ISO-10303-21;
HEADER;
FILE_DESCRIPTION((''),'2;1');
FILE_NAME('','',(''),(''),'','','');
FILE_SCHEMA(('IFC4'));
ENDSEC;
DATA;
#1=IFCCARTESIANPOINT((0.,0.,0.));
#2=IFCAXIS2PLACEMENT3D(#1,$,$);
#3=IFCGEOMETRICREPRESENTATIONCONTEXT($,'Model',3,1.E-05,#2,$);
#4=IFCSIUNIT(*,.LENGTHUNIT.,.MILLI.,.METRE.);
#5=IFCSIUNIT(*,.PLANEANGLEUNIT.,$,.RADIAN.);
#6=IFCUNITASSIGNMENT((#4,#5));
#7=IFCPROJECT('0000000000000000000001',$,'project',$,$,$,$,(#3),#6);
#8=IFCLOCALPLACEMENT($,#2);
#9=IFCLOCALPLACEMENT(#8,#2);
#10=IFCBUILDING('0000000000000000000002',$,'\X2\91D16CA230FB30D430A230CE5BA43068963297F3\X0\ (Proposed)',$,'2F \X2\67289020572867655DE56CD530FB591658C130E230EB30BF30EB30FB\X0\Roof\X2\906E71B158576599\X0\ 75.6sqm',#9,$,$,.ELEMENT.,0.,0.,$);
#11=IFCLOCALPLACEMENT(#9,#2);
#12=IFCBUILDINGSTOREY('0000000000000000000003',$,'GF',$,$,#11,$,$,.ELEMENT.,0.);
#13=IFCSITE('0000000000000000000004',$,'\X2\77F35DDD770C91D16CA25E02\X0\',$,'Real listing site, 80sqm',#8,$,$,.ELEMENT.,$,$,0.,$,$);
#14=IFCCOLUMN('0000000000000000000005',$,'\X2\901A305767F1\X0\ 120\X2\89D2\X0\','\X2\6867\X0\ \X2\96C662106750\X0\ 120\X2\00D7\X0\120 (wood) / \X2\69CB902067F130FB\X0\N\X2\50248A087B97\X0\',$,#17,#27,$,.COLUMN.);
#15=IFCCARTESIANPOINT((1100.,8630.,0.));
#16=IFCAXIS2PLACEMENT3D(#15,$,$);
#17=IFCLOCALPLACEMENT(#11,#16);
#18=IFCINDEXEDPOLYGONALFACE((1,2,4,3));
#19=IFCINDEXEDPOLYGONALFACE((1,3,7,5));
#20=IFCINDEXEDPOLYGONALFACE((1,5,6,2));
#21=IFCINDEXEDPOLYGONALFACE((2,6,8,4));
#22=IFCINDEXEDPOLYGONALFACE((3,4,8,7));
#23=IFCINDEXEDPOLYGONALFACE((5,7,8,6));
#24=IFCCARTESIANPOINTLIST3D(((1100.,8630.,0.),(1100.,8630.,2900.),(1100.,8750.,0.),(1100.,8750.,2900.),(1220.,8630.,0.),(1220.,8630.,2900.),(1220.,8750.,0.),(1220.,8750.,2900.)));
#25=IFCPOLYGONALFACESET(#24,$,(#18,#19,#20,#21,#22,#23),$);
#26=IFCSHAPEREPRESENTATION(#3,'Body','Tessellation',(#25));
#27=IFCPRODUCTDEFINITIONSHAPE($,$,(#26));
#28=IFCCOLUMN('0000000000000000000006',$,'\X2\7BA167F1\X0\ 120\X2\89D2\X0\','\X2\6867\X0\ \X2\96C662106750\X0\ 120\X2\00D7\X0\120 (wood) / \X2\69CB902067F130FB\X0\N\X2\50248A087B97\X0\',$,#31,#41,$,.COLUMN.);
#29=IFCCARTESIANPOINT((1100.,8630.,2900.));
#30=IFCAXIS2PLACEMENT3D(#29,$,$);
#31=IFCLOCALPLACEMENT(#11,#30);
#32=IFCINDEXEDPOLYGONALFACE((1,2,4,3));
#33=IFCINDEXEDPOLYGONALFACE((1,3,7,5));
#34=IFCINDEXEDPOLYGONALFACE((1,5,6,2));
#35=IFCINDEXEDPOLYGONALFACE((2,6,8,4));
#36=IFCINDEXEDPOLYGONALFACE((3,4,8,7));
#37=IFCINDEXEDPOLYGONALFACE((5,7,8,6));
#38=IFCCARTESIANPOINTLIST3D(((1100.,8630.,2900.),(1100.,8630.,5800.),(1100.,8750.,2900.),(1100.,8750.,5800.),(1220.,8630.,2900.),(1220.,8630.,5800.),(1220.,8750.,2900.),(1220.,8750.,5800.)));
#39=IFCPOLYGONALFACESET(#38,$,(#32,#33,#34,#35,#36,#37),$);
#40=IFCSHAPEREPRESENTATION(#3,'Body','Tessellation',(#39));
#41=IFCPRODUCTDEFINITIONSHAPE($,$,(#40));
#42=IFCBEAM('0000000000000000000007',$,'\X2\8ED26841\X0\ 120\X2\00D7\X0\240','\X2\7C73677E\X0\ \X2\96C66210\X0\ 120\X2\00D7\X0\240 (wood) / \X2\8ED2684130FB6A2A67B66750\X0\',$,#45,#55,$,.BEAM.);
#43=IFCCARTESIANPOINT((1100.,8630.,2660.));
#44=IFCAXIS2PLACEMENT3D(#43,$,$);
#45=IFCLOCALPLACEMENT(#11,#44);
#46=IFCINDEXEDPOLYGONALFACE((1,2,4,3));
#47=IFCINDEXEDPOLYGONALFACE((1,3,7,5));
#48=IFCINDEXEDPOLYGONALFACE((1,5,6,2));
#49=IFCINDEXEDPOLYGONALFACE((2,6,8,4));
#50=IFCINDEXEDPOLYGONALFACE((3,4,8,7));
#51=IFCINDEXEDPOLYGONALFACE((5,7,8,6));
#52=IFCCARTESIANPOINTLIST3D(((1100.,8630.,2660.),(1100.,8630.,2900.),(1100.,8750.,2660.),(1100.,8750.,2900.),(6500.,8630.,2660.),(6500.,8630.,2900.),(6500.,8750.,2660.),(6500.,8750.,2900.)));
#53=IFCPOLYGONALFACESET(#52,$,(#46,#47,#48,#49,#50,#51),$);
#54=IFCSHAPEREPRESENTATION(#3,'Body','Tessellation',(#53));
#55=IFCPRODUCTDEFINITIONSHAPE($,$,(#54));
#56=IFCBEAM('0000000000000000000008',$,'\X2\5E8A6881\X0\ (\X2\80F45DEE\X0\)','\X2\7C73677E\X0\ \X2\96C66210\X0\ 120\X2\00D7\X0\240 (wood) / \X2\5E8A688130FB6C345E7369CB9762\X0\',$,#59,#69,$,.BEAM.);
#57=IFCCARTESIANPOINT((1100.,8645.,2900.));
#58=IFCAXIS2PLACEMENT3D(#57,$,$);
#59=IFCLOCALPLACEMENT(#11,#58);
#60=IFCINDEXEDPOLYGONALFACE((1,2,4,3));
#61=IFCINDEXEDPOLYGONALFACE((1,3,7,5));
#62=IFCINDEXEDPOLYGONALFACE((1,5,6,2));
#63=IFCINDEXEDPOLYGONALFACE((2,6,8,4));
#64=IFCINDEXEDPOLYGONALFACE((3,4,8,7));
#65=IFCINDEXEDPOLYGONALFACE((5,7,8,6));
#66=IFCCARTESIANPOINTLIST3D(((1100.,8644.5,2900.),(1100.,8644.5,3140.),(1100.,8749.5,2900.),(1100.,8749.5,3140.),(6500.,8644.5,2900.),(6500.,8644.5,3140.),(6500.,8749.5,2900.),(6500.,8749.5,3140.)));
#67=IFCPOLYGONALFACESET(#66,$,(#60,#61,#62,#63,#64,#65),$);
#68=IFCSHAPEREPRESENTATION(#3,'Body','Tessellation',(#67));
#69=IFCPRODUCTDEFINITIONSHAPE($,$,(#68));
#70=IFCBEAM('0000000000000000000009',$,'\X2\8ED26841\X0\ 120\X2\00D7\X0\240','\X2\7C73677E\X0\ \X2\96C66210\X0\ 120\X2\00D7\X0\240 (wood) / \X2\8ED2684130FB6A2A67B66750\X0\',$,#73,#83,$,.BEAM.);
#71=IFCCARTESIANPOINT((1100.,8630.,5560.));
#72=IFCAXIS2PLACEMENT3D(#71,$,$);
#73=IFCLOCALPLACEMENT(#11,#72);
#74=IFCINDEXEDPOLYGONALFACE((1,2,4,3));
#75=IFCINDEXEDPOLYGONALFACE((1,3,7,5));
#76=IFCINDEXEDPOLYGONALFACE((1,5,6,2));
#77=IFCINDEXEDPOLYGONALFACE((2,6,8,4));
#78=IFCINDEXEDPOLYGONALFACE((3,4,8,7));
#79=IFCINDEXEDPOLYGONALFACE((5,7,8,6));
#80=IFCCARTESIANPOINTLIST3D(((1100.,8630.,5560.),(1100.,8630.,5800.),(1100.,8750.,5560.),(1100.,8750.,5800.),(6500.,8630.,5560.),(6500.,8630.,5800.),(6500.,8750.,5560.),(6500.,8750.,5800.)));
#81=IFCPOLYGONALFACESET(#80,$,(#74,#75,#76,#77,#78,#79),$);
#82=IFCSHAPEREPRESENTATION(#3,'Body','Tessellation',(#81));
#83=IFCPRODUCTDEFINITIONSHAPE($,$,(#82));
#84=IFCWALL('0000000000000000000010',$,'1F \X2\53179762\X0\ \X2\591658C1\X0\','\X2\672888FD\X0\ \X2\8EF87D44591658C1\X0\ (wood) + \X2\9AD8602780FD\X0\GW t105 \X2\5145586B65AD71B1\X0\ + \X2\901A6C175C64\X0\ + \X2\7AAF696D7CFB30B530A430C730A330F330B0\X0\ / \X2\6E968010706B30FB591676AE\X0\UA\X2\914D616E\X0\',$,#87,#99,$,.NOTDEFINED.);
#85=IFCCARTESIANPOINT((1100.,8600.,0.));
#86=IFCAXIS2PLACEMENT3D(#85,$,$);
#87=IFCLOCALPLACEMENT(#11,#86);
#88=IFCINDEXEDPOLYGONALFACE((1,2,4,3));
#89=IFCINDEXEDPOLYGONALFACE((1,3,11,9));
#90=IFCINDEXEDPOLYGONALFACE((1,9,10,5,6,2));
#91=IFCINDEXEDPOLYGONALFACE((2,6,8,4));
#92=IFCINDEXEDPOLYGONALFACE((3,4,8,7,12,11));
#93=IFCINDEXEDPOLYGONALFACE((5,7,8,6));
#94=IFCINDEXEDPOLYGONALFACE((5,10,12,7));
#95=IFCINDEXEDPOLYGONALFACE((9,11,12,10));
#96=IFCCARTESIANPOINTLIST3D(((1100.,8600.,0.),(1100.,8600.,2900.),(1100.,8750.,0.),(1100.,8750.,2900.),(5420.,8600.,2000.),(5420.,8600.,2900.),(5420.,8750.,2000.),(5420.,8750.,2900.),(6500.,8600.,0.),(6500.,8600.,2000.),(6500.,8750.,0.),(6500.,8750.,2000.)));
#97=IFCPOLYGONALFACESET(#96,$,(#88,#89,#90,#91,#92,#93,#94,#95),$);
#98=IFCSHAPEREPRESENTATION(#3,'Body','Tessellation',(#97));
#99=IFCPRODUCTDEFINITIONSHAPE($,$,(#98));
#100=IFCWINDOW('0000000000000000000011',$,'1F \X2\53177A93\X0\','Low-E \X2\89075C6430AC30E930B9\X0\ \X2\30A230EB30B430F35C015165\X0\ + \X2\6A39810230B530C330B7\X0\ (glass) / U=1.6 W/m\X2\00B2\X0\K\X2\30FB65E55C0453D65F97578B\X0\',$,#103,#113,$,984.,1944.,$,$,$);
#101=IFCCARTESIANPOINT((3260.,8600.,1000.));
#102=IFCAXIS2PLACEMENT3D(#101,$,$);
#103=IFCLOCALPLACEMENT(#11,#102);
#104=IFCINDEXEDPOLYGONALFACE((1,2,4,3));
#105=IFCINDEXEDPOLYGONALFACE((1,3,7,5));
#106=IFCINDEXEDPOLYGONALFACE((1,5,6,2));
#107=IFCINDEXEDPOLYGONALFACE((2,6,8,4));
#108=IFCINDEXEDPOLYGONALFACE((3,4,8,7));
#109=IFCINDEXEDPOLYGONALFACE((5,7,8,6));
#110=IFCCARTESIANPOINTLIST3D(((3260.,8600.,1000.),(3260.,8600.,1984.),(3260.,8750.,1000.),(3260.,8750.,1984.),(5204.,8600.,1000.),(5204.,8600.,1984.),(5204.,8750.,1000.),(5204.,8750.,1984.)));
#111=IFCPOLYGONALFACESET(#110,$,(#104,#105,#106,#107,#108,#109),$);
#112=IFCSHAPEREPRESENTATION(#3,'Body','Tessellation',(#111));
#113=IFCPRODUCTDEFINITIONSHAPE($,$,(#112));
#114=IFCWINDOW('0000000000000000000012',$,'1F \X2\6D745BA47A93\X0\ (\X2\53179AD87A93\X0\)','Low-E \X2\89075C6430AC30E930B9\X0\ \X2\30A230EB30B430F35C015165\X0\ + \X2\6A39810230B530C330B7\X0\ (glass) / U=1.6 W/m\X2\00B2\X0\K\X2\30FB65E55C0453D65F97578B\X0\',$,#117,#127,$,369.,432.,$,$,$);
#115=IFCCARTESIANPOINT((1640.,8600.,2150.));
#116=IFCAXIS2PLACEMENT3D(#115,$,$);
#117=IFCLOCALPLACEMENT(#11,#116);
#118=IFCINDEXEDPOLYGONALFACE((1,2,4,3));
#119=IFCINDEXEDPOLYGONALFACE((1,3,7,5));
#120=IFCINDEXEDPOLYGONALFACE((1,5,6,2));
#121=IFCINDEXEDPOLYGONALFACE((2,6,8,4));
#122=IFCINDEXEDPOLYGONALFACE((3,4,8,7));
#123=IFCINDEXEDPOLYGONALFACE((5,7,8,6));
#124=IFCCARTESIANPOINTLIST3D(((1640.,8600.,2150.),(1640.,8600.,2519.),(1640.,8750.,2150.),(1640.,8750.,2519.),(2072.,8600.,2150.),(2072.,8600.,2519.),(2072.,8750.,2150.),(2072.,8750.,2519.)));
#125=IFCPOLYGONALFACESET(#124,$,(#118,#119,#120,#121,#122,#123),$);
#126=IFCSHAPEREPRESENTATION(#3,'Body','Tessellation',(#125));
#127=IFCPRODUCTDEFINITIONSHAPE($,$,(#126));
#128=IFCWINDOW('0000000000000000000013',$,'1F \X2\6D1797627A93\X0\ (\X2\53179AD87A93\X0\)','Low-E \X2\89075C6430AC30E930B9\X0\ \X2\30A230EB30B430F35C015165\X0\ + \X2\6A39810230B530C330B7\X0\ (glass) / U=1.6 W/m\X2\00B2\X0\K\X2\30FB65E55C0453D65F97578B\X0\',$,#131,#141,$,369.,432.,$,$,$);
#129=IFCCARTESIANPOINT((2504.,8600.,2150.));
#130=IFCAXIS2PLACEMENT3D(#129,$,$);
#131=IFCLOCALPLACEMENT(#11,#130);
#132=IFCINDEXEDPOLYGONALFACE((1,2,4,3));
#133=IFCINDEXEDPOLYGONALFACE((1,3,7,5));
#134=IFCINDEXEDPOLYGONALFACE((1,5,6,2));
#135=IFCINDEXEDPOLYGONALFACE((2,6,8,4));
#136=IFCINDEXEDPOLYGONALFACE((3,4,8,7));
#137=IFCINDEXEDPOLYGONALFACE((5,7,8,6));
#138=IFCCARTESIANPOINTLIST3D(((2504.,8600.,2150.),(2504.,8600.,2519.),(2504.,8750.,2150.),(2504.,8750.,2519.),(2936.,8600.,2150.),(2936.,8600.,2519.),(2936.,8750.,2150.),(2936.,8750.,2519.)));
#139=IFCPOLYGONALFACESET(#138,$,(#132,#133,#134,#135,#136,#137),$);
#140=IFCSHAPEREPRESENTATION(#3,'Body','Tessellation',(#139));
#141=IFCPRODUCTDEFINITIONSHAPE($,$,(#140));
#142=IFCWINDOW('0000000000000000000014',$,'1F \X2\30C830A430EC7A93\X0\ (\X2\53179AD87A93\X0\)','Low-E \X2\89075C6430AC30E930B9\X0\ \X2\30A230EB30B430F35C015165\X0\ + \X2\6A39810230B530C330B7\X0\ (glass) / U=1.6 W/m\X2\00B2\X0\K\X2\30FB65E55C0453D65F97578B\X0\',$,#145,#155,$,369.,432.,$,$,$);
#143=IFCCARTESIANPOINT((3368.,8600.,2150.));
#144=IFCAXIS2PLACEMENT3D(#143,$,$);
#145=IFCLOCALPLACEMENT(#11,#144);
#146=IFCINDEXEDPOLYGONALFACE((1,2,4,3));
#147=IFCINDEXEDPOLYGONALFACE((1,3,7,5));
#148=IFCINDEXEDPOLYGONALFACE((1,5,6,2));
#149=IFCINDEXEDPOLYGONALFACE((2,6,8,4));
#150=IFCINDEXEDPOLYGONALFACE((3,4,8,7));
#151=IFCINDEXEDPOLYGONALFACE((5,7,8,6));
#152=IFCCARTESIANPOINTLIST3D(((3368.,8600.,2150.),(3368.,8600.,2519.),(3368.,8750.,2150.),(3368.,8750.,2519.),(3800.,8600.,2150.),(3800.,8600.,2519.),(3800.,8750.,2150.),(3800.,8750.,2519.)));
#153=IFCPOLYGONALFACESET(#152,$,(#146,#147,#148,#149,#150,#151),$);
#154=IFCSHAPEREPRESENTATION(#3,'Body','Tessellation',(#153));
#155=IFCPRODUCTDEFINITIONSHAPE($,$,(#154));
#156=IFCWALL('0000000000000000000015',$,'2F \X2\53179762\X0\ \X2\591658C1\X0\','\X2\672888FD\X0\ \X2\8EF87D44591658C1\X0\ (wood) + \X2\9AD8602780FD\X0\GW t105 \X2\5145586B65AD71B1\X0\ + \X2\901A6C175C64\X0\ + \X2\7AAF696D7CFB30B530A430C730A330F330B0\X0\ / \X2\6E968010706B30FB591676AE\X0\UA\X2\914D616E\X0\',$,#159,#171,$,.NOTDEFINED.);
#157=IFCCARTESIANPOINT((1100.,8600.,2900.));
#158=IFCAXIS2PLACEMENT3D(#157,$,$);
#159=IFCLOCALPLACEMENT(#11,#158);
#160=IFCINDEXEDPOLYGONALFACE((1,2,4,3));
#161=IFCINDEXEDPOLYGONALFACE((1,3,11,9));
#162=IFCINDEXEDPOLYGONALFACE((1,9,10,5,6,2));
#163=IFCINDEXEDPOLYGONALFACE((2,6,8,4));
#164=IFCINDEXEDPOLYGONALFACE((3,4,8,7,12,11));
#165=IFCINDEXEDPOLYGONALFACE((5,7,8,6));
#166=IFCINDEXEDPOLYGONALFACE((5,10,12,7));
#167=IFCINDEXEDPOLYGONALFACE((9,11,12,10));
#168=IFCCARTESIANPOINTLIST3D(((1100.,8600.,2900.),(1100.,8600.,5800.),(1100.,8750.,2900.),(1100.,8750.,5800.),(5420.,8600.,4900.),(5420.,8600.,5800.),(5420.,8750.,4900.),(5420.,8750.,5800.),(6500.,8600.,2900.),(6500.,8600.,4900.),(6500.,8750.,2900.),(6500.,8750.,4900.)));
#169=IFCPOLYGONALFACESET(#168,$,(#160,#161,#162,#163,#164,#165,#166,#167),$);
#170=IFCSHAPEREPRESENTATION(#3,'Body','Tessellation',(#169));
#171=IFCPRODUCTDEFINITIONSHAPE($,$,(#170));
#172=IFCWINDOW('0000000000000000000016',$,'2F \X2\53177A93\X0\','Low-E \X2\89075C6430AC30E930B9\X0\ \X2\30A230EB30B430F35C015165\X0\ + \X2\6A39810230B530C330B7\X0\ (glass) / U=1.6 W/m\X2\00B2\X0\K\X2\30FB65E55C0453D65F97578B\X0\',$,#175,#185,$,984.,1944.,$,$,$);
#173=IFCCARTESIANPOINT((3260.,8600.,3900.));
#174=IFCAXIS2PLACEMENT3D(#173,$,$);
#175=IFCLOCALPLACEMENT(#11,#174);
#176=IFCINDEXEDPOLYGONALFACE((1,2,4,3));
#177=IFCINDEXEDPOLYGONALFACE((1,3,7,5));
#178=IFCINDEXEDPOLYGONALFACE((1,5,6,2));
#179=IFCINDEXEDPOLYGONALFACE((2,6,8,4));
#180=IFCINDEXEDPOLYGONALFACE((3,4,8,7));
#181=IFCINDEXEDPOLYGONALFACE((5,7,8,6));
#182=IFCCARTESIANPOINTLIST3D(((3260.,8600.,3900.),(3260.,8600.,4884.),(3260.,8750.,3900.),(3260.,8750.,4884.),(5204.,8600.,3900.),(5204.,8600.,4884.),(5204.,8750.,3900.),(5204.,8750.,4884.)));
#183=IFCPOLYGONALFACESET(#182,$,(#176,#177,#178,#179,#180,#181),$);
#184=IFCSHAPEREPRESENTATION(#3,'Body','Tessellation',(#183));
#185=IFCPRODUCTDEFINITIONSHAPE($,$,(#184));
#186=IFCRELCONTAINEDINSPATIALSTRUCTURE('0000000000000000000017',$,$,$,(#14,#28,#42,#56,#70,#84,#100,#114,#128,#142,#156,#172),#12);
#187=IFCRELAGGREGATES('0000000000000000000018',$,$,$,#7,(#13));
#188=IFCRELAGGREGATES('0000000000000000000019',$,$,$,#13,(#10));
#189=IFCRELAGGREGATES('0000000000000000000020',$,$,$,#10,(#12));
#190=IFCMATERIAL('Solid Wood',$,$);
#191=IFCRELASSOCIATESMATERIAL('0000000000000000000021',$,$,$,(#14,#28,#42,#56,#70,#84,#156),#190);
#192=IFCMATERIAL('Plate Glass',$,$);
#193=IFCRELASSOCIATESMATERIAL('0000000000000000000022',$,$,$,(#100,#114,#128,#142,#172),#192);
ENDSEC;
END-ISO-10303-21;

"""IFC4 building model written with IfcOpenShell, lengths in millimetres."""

from ifc_helpers import new_model, si_unit, frame, frame_2d, origin, place, context, project, spatial, rectangle, extrude, material, element, fill, save


model = new_model("IFC4")

# Units and contexts
model_context = context("Model", 3, precision=1e-05, world=origin())
ifc_project = project(units=[si_unit("LENGTHUNIT", "METRE", prefix="MILLI"), si_unit("PLANEANGLEUNIT", "RADIAN")], contexts=[model_context])

# Site, building, storey
site_placement = place(None, origin())
site = spatial("IfcSite", under=ifc_project, at=site_placement, Name="石川県金沢市", ObjectType="Real listing site, 80sqm", CompositionType="ELEMENT", RefElevation=0.0)
building_placement = place(site_placement, origin())
building = spatial("IfcBuilding", under=site, at=building_placement, Name="金沢・ピアノ室と防音 (Proposed)", ObjectType="2F 木造在来工法・外壁モルタル・Roof遮熱塗料 75.6sqm", CompositionType="ELEMENT", ElevationOfRefHeight=0.0, ElevationOfTerrain=0.0)
storey_placement = place(building_placement, origin())
storey = spatial("IfcBuildingStorey", under=building, at=storey_placement, Name="GF", CompositionType="ELEMENT", Elevation=0.0)

# Columns
ifc_material_1 = material(Name="Solid Wood")
column_1_placement = place(storey_placement, frame((1100.0, 8630.0, 0.0)))
element("IfcColumn", 1, at=column_1_placement, inside=storey, material=ifc_material_1, Name="通し柱 120角", Description="桧 集成材 120×120 (wood) / 構造柱・N値計算", PredefinedType="COLUMN", context=model_context, shape_type="SweptSolid", body=[
    extrude(rectangle(XDim=120.0, YDim=120.0, at=frame_2d((60.0, 60.0))), frame((1100.0, 8630.0, 0.0)), (0.0, 0.0, 1.0), 2900.0),
])
column_2_placement = place(storey_placement, frame((1100.0, 8630.0, 2900.0)))
element("IfcColumn", 2, at=column_2_placement, inside=storey, material=ifc_material_1, Name="管柱 120角", Description="桧 集成材 120×120 (wood) / 構造柱・N値計算", PredefinedType="COLUMN", context=model_context, shape_type="SweptSolid", body=[
    extrude(rectangle(XDim=120.0, YDim=120.0, at=frame_2d((60.0, 60.0))), frame((1100.0, 8630.0, 2900.0)), (0.0, 0.0, 1.0), 2900.0),
])

# Beams
beam_1_placement = place(storey_placement, frame((1100.0, 8630.0, 2660.0)))
element("IfcBeam", 3, at=beam_1_placement, inside=storey, material=ifc_material_1, Name="軒桁 120×240", Description="米松 集成 120×240 (wood) / 軒桁・横架材", PredefinedType="BEAM", context=model_context, shape_type="SweptSolid", body=[
    extrude(rectangle(XDim=5400.0, YDim=120.0, at=frame_2d((2700.0, 60.0))), frame((1100.0, 8630.0, 2660.0)), (0.0, 0.0, 1.0), 240.0),
])
beam_2_placement = place(storey_placement, frame((1100.0, 8645.0, 2900.0)))
element("IfcBeam", 4, at=beam_2_placement, inside=storey, material=ifc_material_1, Name="床梁 (胴差)", Description="米松 集成 120×240 (wood) / 床梁・水平構面", PredefinedType="BEAM", context=model_context, shape_type="SweptSolid", body=[
    extrude(rectangle(XDim=5400.0, YDim=105.0, at=frame_2d((2700.0, 52.0))), frame((1100.0, 8645.0, 2900.0)), (0.0, 0.0, 1.0), 240.0),
])
beam_3_placement = place(storey_placement, frame((1100.0, 8630.0, 5560.0)))
element("IfcBeam", 5, at=beam_3_placement, inside=storey, material=ifc_material_1, Name="軒桁 120×240", Description="米松 集成 120×240 (wood) / 軒桁・横架材", PredefinedType="BEAM", context=model_context, shape_type="SweptSolid", body=[
    extrude(rectangle(XDim=5400.0, YDim=120.0, at=frame_2d((2700.0, 60.0))), frame((1100.0, 8630.0, 5560.0)), (0.0, 0.0, 1.0), 240.0),
])

# Wall, openings, windows
wall_1_placement = place(storey_placement, frame((1100.0, 8600.0, 0.0)))
wall_1 = element("IfcWall", 6, at=wall_1_placement, inside=storey, material=ifc_material_1, Name="1F 北面 外壁", Description="木製 軸組外壁 (wood) + 高性能GW t105 充填断熱 + 通気層 + 窯業系サイディング / 準耐火・外皮UA配慮", PredefinedType="NOTDEFINED", context=model_context, shape_type="SweptSolid", body=[
    extrude(rectangle(XDim=5400.0, YDim=150.0, at=frame_2d((2700.0, 75.0))), frame((1100.0, 8600.0, 0.0)), (0.0, 0.0, 1.0), 2900.0),
])
opening_1_placement = place(storey_placement, frame((3260.0, 8600.0, 1000.0)))
opening_1 = element("IfcOpeningElement", 7, at=opening_1_placement, cuts=wall_1, PredefinedType="NOTDEFINED", context=model_context, shape_type="SweptSolid", body=[
    extrude(rectangle(XDim=1944.0, YDim=150.0, at=frame_2d((972.0, 75.0))), frame((3260.0, 8600.0, 1000.0)), (0.0, 0.0, 1.0), 984.0),
])
opening_2_placement = place(storey_placement, frame((1640.0, 8600.0, 2150.0)))
opening_2 = element("IfcOpeningElement", 8, at=opening_2_placement, cuts=wall_1, PredefinedType="NOTDEFINED", context=model_context, shape_type="SweptSolid", body=[
    extrude(rectangle(XDim=432.0, YDim=150.0, at=frame_2d((216.0, 75.0))), frame((1640.0, 8600.0, 2150.0)), (0.0, 0.0, 1.0), 369.0),
])
opening_3_placement = place(storey_placement, frame((2504.0, 8600.0, 2150.0)))
opening_3 = element("IfcOpeningElement", 9, at=opening_3_placement, cuts=wall_1, PredefinedType="NOTDEFINED", context=model_context, shape_type="SweptSolid", body=[
    extrude(rectangle(XDim=432.0, YDim=150.0, at=frame_2d((216.0, 75.0))), frame((2504.0, 8600.0, 2150.0)), (0.0, 0.0, 1.0), 369.0),
])
opening_4_placement = place(storey_placement, frame((3368.0, 8600.0, 2150.0)))
opening_4 = element("IfcOpeningElement", 10, at=opening_4_placement, cuts=wall_1, PredefinedType="NOTDEFINED", context=model_context, shape_type="SweptSolid", body=[
    extrude(rectangle(XDim=432.0, YDim=150.0, at=frame_2d((216.0, 75.0))), frame((3368.0, 8600.0, 2150.0)), (0.0, 0.0, 1.0), 369.0),
])
ifc_material_2 = material(Name="Plate Glass")
window_1_placement = place(storey_placement, frame((3260.0, 8600.0, 1000.0)))
window_1 = element("IfcWindow", 11, at=window_1_placement, inside=storey, material=ifc_material_2, Name="1F 北窓", Description="Low-E 複層ガラス アルゴン封入 + 樹脂サッシ (glass) / U=1.6 W/m²K・日射取得型", OverallHeight=984.0, OverallWidth=1944.0, context=model_context, shape_type="SweptSolid", body=[
    extrude(rectangle(XDim=1944.0, YDim=150.0, at=frame_2d((972.0, 75.0))), frame((3260.0, 8600.0, 1000.0)), (0.0, 0.0, 1.0), 984.0),
])
fill(opening_1, window_1)
window_2_placement = place(storey_placement, frame((1640.0, 8600.0, 2150.0)))
window_2 = element("IfcWindow", 12, at=window_2_placement, inside=storey, material=ifc_material_2, Name="1F 浴室窓 (北高窓)", Description="Low-E 複層ガラス アルゴン封入 + 樹脂サッシ (glass) / U=1.6 W/m²K・日射取得型", OverallHeight=369.0, OverallWidth=432.0, context=model_context, shape_type="SweptSolid", body=[
    extrude(rectangle(XDim=432.0, YDim=150.0, at=frame_2d((216.0, 75.0))), frame((1640.0, 8600.0, 2150.0)), (0.0, 0.0, 1.0), 369.0),
])
fill(opening_2, window_2)
window_3_placement = place(storey_placement, frame((2504.0, 8600.0, 2150.0)))
window_3 = element("IfcWindow", 13, at=window_3_placement, inside=storey, material=ifc_material_2, Name="1F 洗面窓 (北高窓)", Description="Low-E 複層ガラス アルゴン封入 + 樹脂サッシ (glass) / U=1.6 W/m²K・日射取得型", OverallHeight=369.0, OverallWidth=432.0, context=model_context, shape_type="SweptSolid", body=[
    extrude(rectangle(XDim=432.0, YDim=150.0, at=frame_2d((216.0, 75.0))), frame((2504.0, 8600.0, 2150.0)), (0.0, 0.0, 1.0), 369.0),
])
fill(opening_3, window_3)
window_4_placement = place(storey_placement, frame((3368.0, 8600.0, 2150.0)))
window_4 = element("IfcWindow", 14, at=window_4_placement, inside=storey, material=ifc_material_2, Name="1F トイレ窓 (北高窓)", Description="Low-E 複層ガラス アルゴン封入 + 樹脂サッシ (glass) / U=1.6 W/m²K・日射取得型", OverallHeight=369.0, OverallWidth=432.0, context=model_context, shape_type="SweptSolid", body=[
    extrude(rectangle(XDim=432.0, YDim=150.0, at=frame_2d((216.0, 75.0))), frame((3368.0, 8600.0, 2150.0)), (0.0, 0.0, 1.0), 369.0),
])
fill(opening_4, window_4)

# Wall, opening, window
wall_2_placement = place(storey_placement, frame((1100.0, 8600.0, 2900.0)))
wall_2 = element("IfcWall", 15, at=wall_2_placement, inside=storey, material=ifc_material_1, Name="2F 北面 外壁", Description="木製 軸組外壁 (wood) + 高性能GW t105 充填断熱 + 通気層 + 窯業系サイディング / 準耐火・外皮UA配慮", PredefinedType="NOTDEFINED", context=model_context, shape_type="SweptSolid", body=[
    extrude(rectangle(XDim=5400.0, YDim=150.0, at=frame_2d((2700.0, 75.0))), frame((1100.0, 8600.0, 2900.0)), (0.0, 0.0, 1.0), 2900.0),
])
opening_5_placement = place(storey_placement, frame((3260.0, 8600.0, 3900.0)))
opening_5 = element("IfcOpeningElement", 16, at=opening_5_placement, cuts=wall_2, PredefinedType="NOTDEFINED", context=model_context, shape_type="SweptSolid", body=[
    extrude(rectangle(XDim=1944.0, YDim=150.0, at=frame_2d((972.0, 75.0))), frame((3260.0, 8600.0, 3900.0)), (0.0, 0.0, 1.0), 984.0),
])
window_5_placement = place(storey_placement, frame((3260.0, 8600.0, 3900.0)))
window_5 = element("IfcWindow", 17, at=window_5_placement, inside=storey, material=ifc_material_2, Name="2F 北窓", Description="Low-E 複層ガラス アルゴン封入 + 樹脂サッシ (glass) / U=1.6 W/m²K・日射取得型", OverallHeight=984.0, OverallWidth=1944.0, context=model_context, shape_type="SweptSolid", body=[
    extrude(rectangle(XDim=1944.0, YDim=150.0, at=frame_2d((972.0, 75.0))), frame((3260.0, 8600.0, 3900.0)), (0.0, 0.0, 1.0), 984.0),
])
fill(opening_5, window_5)

save(model, "model.ifc")
